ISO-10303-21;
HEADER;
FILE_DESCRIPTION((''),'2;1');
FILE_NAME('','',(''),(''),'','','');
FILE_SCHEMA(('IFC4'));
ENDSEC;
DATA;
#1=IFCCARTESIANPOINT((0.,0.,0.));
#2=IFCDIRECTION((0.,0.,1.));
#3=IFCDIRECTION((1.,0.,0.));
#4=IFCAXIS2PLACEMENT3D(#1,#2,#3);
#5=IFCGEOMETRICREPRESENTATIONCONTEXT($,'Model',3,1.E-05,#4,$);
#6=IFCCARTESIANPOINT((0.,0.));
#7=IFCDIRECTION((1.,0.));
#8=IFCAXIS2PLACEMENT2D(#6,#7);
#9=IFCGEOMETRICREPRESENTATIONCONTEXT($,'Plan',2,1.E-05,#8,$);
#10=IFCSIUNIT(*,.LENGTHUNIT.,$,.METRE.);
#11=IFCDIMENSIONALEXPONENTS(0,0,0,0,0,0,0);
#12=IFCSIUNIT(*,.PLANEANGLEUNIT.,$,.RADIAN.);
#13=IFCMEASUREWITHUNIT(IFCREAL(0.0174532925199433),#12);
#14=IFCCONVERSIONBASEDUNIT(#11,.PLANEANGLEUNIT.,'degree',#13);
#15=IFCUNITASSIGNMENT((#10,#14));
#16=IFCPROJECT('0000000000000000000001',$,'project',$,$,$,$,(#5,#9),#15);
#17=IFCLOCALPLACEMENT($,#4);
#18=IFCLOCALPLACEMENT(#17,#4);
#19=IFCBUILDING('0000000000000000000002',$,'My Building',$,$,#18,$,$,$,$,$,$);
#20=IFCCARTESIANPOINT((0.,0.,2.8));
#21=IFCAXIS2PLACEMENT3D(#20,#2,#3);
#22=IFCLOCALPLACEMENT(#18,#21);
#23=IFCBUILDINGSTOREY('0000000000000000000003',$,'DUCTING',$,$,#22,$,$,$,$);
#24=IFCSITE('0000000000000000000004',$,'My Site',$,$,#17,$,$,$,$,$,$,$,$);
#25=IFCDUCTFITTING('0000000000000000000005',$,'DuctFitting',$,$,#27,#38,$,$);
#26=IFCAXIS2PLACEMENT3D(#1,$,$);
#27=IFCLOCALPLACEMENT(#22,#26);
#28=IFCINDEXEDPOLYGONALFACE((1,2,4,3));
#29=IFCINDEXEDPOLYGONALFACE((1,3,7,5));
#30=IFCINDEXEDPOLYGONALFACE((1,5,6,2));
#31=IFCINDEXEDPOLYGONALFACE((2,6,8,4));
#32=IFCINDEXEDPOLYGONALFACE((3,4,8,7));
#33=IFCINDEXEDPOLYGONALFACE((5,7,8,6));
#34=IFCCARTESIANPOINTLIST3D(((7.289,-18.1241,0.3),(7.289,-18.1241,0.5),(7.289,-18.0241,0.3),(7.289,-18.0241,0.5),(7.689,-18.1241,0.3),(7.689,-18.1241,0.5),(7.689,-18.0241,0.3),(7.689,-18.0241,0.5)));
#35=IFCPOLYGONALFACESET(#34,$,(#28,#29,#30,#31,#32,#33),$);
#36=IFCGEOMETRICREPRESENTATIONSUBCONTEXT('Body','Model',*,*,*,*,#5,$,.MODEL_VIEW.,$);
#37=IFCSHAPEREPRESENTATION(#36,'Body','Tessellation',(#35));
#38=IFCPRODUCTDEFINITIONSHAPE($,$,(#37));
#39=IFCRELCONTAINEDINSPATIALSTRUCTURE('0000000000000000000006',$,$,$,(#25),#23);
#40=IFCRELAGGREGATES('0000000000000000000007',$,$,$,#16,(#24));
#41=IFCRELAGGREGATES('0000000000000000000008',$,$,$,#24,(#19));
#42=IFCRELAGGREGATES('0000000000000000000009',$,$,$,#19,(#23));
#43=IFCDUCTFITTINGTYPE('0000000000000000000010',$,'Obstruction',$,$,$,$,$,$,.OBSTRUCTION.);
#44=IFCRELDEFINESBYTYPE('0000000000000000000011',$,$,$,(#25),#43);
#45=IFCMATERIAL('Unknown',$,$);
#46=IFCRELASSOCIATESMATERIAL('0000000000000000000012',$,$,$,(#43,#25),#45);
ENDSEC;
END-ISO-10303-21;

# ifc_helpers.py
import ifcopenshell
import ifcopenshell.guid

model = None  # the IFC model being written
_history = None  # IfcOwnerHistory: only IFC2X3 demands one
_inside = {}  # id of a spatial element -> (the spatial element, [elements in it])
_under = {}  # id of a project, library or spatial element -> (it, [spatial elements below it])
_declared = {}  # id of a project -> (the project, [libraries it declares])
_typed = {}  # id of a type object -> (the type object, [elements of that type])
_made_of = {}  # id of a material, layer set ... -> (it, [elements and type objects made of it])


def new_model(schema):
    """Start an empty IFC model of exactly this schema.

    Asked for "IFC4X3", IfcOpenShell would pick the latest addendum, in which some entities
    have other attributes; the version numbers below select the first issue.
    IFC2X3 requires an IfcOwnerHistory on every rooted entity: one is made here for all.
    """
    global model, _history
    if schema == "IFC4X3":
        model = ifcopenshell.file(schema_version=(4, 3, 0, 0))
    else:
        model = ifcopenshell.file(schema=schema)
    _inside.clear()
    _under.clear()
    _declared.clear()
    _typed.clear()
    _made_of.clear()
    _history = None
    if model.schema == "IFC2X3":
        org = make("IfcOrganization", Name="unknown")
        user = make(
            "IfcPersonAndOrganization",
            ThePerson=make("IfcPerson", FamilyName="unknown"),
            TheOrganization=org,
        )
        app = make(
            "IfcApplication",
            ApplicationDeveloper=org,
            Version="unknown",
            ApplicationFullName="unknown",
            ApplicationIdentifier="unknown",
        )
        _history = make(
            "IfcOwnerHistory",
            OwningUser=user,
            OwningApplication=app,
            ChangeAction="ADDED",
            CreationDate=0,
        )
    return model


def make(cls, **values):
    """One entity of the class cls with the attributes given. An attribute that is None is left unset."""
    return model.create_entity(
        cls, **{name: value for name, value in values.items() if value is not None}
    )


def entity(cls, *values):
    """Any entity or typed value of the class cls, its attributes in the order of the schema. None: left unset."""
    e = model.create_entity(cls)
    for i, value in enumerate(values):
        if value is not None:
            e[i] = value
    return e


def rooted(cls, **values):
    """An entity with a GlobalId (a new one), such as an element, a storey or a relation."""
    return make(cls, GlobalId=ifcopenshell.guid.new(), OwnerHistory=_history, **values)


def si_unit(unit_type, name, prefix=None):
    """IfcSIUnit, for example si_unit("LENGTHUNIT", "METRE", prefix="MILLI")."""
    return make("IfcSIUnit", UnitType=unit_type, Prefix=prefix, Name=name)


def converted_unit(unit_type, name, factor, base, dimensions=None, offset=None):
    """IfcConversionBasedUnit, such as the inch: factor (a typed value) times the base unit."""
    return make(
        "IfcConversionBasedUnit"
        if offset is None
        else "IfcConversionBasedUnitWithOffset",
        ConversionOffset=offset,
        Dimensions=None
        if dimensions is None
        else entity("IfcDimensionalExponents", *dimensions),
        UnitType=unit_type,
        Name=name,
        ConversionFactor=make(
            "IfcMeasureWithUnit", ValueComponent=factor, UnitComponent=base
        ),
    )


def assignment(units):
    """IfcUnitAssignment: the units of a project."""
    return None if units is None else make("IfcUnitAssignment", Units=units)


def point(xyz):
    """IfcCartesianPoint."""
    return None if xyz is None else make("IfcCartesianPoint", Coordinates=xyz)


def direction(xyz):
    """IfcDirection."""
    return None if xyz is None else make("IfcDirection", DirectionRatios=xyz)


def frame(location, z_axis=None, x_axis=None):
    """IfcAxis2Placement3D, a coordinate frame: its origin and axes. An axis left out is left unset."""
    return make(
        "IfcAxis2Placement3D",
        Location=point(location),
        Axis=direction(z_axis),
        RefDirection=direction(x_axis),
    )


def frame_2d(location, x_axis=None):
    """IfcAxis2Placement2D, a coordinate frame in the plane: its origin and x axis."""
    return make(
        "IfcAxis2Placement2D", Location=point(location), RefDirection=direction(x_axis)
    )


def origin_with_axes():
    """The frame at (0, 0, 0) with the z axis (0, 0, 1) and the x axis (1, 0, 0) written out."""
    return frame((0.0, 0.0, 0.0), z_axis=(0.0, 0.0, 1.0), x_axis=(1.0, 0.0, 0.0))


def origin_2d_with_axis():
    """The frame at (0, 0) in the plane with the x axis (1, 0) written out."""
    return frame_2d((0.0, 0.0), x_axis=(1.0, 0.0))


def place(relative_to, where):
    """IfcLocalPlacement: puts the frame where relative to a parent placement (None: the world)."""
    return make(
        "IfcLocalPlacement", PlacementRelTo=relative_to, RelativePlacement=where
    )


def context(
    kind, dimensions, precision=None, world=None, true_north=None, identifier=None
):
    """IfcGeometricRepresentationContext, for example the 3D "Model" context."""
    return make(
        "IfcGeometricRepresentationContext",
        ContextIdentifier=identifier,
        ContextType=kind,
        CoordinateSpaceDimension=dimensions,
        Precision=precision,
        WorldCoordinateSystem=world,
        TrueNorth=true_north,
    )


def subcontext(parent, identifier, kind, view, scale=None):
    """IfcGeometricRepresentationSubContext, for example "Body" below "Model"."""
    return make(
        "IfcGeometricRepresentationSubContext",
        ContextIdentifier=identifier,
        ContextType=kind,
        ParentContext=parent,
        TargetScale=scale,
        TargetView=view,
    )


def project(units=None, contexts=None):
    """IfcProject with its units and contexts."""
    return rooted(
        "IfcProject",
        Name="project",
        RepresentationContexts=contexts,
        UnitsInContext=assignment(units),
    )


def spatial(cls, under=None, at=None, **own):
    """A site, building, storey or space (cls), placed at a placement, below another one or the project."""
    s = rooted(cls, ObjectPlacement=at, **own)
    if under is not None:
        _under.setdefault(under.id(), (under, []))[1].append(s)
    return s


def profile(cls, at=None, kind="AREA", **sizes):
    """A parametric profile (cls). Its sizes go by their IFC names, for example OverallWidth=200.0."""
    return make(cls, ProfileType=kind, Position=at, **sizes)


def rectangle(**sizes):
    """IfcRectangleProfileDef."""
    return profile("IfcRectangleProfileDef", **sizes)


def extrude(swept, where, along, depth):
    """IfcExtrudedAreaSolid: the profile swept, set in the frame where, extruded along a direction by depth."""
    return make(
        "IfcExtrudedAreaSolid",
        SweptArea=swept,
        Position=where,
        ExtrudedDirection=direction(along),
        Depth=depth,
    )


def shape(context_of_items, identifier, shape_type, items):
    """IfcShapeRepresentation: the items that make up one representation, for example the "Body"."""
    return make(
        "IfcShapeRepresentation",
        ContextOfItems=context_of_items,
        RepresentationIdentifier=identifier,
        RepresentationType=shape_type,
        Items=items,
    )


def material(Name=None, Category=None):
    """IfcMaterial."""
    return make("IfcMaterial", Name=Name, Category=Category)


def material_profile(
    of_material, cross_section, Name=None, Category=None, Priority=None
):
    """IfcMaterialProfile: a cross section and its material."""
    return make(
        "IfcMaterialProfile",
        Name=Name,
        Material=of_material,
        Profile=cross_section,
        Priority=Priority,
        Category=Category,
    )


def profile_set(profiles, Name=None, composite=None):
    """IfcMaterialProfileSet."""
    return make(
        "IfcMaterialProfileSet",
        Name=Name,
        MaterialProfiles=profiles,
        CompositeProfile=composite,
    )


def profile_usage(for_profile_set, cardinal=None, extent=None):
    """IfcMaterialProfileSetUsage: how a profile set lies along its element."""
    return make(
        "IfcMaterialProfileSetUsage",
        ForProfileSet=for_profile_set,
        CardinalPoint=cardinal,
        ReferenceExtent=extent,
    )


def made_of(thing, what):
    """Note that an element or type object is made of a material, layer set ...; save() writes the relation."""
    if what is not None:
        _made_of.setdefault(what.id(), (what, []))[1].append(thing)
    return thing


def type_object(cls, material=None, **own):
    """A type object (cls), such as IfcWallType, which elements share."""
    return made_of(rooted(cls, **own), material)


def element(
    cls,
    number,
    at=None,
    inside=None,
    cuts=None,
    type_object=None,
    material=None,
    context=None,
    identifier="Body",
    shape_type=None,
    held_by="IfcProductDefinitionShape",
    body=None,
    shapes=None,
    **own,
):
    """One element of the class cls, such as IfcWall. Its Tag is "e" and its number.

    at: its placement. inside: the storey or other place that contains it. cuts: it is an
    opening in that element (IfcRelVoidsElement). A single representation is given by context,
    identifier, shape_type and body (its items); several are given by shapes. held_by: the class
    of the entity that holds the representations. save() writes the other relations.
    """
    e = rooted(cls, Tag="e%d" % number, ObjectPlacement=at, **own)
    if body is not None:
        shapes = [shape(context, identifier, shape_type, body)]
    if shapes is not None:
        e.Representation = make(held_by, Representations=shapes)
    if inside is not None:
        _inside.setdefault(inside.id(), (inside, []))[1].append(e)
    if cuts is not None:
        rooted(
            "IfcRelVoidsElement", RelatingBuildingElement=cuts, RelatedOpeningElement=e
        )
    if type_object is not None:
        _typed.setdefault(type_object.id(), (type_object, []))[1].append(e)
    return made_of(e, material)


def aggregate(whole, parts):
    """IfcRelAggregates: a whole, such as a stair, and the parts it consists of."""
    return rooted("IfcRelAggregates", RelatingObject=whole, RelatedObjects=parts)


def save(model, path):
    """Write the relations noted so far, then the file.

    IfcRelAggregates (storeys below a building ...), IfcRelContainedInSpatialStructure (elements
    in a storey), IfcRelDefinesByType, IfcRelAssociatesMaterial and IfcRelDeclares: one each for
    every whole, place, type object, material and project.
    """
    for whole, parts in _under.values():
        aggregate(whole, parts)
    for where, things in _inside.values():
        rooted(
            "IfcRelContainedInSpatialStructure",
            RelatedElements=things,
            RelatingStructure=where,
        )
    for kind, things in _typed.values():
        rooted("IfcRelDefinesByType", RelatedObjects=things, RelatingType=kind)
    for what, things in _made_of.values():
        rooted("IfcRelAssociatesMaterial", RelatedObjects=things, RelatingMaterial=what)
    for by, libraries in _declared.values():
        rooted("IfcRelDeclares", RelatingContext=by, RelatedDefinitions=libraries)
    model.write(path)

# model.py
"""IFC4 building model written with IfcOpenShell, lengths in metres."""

from ifc_helpers import new_model, entity, si_unit, converted_unit, frame, origin_with_axes, origin_2d_with_axis, place, context, subcontext, project, spatial, rectangle, extrude, material, material_profile, profile_set, profile_usage, type_object, element, save


model = new_model("IFC4")

# Units and contexts
model_context = context("Model", 3, precision=1e-05, world=origin_with_axes())
plan_context = context("Plan", 2, precision=1e-05, world=origin_2d_with_axis())
body_context = subcontext(model_context, "Body", "Model", "MODEL_VIEW")
ifc_project = project(units=[si_unit("LENGTHUNIT", "METRE"), converted_unit("PLANEANGLEUNIT", "degree", entity("IfcReal", 0.0174532925199433), si_unit("PLANEANGLEUNIT", "RADIAN"), dimensions=[0, 0, 0, 0, 0, 0, 0])], contexts=[model_context, plan_context])

# Site, building, storey
site_placement = place(None, origin_with_axes())
site = spatial("IfcSite", under=ifc_project, at=site_placement, Name="My Site")
building_placement = place(site_placement, origin_with_axes())
building = spatial("IfcBuilding", under=site, at=building_placement, Name="My Building")
storey_placement = place(building_placement, frame((0.0, 0.0, 2.8), z_axis=(0.0, 0.0, 1.0), x_axis=(1.0, 0.0, 0.0)))
storey = spatial("IfcBuildingStorey", under=building, at=storey_placement, Name="DUCTING")

# Shared definitions
ifc_material = material(Name="Unknown")

# Duct fitting
ifc_material_profile_1 = material_profile(ifc_material, rectangle(XDim=0.4, YDim=0.2))
ifc_profile_set_1 = profile_set([ifc_material_profile_1])
duct_fitting_type_1 = type_object("IfcDuctFittingType", Name="Obstruction", PredefinedType="OBSTRUCTION", material=ifc_profile_set_1)
ifc_profile_usage_1 = profile_usage(ifc_profile_set_1, cardinal=5)
duct_fitting_1_placement = place(storey_placement, frame((7.489, -18.0241, 0.4), z_axis=(0.0, -1.0, 0.000005), x_axis=(1.0, 0.0, 0.0)))
element("IfcDuctFitting", 1, at=duct_fitting_1_placement, inside=storey, type_object=duct_fitting_type_1, material=ifc_profile_usage_1, Name="DuctFitting", context=body_context, shape_type="SweptSolid", body=[
    extrude(rectangle(XDim=0.4, YDim=0.2), origin_with_axes(), (0.0, 0.0, 1.0), 0.1),
])

save(model, "model.ifc")
